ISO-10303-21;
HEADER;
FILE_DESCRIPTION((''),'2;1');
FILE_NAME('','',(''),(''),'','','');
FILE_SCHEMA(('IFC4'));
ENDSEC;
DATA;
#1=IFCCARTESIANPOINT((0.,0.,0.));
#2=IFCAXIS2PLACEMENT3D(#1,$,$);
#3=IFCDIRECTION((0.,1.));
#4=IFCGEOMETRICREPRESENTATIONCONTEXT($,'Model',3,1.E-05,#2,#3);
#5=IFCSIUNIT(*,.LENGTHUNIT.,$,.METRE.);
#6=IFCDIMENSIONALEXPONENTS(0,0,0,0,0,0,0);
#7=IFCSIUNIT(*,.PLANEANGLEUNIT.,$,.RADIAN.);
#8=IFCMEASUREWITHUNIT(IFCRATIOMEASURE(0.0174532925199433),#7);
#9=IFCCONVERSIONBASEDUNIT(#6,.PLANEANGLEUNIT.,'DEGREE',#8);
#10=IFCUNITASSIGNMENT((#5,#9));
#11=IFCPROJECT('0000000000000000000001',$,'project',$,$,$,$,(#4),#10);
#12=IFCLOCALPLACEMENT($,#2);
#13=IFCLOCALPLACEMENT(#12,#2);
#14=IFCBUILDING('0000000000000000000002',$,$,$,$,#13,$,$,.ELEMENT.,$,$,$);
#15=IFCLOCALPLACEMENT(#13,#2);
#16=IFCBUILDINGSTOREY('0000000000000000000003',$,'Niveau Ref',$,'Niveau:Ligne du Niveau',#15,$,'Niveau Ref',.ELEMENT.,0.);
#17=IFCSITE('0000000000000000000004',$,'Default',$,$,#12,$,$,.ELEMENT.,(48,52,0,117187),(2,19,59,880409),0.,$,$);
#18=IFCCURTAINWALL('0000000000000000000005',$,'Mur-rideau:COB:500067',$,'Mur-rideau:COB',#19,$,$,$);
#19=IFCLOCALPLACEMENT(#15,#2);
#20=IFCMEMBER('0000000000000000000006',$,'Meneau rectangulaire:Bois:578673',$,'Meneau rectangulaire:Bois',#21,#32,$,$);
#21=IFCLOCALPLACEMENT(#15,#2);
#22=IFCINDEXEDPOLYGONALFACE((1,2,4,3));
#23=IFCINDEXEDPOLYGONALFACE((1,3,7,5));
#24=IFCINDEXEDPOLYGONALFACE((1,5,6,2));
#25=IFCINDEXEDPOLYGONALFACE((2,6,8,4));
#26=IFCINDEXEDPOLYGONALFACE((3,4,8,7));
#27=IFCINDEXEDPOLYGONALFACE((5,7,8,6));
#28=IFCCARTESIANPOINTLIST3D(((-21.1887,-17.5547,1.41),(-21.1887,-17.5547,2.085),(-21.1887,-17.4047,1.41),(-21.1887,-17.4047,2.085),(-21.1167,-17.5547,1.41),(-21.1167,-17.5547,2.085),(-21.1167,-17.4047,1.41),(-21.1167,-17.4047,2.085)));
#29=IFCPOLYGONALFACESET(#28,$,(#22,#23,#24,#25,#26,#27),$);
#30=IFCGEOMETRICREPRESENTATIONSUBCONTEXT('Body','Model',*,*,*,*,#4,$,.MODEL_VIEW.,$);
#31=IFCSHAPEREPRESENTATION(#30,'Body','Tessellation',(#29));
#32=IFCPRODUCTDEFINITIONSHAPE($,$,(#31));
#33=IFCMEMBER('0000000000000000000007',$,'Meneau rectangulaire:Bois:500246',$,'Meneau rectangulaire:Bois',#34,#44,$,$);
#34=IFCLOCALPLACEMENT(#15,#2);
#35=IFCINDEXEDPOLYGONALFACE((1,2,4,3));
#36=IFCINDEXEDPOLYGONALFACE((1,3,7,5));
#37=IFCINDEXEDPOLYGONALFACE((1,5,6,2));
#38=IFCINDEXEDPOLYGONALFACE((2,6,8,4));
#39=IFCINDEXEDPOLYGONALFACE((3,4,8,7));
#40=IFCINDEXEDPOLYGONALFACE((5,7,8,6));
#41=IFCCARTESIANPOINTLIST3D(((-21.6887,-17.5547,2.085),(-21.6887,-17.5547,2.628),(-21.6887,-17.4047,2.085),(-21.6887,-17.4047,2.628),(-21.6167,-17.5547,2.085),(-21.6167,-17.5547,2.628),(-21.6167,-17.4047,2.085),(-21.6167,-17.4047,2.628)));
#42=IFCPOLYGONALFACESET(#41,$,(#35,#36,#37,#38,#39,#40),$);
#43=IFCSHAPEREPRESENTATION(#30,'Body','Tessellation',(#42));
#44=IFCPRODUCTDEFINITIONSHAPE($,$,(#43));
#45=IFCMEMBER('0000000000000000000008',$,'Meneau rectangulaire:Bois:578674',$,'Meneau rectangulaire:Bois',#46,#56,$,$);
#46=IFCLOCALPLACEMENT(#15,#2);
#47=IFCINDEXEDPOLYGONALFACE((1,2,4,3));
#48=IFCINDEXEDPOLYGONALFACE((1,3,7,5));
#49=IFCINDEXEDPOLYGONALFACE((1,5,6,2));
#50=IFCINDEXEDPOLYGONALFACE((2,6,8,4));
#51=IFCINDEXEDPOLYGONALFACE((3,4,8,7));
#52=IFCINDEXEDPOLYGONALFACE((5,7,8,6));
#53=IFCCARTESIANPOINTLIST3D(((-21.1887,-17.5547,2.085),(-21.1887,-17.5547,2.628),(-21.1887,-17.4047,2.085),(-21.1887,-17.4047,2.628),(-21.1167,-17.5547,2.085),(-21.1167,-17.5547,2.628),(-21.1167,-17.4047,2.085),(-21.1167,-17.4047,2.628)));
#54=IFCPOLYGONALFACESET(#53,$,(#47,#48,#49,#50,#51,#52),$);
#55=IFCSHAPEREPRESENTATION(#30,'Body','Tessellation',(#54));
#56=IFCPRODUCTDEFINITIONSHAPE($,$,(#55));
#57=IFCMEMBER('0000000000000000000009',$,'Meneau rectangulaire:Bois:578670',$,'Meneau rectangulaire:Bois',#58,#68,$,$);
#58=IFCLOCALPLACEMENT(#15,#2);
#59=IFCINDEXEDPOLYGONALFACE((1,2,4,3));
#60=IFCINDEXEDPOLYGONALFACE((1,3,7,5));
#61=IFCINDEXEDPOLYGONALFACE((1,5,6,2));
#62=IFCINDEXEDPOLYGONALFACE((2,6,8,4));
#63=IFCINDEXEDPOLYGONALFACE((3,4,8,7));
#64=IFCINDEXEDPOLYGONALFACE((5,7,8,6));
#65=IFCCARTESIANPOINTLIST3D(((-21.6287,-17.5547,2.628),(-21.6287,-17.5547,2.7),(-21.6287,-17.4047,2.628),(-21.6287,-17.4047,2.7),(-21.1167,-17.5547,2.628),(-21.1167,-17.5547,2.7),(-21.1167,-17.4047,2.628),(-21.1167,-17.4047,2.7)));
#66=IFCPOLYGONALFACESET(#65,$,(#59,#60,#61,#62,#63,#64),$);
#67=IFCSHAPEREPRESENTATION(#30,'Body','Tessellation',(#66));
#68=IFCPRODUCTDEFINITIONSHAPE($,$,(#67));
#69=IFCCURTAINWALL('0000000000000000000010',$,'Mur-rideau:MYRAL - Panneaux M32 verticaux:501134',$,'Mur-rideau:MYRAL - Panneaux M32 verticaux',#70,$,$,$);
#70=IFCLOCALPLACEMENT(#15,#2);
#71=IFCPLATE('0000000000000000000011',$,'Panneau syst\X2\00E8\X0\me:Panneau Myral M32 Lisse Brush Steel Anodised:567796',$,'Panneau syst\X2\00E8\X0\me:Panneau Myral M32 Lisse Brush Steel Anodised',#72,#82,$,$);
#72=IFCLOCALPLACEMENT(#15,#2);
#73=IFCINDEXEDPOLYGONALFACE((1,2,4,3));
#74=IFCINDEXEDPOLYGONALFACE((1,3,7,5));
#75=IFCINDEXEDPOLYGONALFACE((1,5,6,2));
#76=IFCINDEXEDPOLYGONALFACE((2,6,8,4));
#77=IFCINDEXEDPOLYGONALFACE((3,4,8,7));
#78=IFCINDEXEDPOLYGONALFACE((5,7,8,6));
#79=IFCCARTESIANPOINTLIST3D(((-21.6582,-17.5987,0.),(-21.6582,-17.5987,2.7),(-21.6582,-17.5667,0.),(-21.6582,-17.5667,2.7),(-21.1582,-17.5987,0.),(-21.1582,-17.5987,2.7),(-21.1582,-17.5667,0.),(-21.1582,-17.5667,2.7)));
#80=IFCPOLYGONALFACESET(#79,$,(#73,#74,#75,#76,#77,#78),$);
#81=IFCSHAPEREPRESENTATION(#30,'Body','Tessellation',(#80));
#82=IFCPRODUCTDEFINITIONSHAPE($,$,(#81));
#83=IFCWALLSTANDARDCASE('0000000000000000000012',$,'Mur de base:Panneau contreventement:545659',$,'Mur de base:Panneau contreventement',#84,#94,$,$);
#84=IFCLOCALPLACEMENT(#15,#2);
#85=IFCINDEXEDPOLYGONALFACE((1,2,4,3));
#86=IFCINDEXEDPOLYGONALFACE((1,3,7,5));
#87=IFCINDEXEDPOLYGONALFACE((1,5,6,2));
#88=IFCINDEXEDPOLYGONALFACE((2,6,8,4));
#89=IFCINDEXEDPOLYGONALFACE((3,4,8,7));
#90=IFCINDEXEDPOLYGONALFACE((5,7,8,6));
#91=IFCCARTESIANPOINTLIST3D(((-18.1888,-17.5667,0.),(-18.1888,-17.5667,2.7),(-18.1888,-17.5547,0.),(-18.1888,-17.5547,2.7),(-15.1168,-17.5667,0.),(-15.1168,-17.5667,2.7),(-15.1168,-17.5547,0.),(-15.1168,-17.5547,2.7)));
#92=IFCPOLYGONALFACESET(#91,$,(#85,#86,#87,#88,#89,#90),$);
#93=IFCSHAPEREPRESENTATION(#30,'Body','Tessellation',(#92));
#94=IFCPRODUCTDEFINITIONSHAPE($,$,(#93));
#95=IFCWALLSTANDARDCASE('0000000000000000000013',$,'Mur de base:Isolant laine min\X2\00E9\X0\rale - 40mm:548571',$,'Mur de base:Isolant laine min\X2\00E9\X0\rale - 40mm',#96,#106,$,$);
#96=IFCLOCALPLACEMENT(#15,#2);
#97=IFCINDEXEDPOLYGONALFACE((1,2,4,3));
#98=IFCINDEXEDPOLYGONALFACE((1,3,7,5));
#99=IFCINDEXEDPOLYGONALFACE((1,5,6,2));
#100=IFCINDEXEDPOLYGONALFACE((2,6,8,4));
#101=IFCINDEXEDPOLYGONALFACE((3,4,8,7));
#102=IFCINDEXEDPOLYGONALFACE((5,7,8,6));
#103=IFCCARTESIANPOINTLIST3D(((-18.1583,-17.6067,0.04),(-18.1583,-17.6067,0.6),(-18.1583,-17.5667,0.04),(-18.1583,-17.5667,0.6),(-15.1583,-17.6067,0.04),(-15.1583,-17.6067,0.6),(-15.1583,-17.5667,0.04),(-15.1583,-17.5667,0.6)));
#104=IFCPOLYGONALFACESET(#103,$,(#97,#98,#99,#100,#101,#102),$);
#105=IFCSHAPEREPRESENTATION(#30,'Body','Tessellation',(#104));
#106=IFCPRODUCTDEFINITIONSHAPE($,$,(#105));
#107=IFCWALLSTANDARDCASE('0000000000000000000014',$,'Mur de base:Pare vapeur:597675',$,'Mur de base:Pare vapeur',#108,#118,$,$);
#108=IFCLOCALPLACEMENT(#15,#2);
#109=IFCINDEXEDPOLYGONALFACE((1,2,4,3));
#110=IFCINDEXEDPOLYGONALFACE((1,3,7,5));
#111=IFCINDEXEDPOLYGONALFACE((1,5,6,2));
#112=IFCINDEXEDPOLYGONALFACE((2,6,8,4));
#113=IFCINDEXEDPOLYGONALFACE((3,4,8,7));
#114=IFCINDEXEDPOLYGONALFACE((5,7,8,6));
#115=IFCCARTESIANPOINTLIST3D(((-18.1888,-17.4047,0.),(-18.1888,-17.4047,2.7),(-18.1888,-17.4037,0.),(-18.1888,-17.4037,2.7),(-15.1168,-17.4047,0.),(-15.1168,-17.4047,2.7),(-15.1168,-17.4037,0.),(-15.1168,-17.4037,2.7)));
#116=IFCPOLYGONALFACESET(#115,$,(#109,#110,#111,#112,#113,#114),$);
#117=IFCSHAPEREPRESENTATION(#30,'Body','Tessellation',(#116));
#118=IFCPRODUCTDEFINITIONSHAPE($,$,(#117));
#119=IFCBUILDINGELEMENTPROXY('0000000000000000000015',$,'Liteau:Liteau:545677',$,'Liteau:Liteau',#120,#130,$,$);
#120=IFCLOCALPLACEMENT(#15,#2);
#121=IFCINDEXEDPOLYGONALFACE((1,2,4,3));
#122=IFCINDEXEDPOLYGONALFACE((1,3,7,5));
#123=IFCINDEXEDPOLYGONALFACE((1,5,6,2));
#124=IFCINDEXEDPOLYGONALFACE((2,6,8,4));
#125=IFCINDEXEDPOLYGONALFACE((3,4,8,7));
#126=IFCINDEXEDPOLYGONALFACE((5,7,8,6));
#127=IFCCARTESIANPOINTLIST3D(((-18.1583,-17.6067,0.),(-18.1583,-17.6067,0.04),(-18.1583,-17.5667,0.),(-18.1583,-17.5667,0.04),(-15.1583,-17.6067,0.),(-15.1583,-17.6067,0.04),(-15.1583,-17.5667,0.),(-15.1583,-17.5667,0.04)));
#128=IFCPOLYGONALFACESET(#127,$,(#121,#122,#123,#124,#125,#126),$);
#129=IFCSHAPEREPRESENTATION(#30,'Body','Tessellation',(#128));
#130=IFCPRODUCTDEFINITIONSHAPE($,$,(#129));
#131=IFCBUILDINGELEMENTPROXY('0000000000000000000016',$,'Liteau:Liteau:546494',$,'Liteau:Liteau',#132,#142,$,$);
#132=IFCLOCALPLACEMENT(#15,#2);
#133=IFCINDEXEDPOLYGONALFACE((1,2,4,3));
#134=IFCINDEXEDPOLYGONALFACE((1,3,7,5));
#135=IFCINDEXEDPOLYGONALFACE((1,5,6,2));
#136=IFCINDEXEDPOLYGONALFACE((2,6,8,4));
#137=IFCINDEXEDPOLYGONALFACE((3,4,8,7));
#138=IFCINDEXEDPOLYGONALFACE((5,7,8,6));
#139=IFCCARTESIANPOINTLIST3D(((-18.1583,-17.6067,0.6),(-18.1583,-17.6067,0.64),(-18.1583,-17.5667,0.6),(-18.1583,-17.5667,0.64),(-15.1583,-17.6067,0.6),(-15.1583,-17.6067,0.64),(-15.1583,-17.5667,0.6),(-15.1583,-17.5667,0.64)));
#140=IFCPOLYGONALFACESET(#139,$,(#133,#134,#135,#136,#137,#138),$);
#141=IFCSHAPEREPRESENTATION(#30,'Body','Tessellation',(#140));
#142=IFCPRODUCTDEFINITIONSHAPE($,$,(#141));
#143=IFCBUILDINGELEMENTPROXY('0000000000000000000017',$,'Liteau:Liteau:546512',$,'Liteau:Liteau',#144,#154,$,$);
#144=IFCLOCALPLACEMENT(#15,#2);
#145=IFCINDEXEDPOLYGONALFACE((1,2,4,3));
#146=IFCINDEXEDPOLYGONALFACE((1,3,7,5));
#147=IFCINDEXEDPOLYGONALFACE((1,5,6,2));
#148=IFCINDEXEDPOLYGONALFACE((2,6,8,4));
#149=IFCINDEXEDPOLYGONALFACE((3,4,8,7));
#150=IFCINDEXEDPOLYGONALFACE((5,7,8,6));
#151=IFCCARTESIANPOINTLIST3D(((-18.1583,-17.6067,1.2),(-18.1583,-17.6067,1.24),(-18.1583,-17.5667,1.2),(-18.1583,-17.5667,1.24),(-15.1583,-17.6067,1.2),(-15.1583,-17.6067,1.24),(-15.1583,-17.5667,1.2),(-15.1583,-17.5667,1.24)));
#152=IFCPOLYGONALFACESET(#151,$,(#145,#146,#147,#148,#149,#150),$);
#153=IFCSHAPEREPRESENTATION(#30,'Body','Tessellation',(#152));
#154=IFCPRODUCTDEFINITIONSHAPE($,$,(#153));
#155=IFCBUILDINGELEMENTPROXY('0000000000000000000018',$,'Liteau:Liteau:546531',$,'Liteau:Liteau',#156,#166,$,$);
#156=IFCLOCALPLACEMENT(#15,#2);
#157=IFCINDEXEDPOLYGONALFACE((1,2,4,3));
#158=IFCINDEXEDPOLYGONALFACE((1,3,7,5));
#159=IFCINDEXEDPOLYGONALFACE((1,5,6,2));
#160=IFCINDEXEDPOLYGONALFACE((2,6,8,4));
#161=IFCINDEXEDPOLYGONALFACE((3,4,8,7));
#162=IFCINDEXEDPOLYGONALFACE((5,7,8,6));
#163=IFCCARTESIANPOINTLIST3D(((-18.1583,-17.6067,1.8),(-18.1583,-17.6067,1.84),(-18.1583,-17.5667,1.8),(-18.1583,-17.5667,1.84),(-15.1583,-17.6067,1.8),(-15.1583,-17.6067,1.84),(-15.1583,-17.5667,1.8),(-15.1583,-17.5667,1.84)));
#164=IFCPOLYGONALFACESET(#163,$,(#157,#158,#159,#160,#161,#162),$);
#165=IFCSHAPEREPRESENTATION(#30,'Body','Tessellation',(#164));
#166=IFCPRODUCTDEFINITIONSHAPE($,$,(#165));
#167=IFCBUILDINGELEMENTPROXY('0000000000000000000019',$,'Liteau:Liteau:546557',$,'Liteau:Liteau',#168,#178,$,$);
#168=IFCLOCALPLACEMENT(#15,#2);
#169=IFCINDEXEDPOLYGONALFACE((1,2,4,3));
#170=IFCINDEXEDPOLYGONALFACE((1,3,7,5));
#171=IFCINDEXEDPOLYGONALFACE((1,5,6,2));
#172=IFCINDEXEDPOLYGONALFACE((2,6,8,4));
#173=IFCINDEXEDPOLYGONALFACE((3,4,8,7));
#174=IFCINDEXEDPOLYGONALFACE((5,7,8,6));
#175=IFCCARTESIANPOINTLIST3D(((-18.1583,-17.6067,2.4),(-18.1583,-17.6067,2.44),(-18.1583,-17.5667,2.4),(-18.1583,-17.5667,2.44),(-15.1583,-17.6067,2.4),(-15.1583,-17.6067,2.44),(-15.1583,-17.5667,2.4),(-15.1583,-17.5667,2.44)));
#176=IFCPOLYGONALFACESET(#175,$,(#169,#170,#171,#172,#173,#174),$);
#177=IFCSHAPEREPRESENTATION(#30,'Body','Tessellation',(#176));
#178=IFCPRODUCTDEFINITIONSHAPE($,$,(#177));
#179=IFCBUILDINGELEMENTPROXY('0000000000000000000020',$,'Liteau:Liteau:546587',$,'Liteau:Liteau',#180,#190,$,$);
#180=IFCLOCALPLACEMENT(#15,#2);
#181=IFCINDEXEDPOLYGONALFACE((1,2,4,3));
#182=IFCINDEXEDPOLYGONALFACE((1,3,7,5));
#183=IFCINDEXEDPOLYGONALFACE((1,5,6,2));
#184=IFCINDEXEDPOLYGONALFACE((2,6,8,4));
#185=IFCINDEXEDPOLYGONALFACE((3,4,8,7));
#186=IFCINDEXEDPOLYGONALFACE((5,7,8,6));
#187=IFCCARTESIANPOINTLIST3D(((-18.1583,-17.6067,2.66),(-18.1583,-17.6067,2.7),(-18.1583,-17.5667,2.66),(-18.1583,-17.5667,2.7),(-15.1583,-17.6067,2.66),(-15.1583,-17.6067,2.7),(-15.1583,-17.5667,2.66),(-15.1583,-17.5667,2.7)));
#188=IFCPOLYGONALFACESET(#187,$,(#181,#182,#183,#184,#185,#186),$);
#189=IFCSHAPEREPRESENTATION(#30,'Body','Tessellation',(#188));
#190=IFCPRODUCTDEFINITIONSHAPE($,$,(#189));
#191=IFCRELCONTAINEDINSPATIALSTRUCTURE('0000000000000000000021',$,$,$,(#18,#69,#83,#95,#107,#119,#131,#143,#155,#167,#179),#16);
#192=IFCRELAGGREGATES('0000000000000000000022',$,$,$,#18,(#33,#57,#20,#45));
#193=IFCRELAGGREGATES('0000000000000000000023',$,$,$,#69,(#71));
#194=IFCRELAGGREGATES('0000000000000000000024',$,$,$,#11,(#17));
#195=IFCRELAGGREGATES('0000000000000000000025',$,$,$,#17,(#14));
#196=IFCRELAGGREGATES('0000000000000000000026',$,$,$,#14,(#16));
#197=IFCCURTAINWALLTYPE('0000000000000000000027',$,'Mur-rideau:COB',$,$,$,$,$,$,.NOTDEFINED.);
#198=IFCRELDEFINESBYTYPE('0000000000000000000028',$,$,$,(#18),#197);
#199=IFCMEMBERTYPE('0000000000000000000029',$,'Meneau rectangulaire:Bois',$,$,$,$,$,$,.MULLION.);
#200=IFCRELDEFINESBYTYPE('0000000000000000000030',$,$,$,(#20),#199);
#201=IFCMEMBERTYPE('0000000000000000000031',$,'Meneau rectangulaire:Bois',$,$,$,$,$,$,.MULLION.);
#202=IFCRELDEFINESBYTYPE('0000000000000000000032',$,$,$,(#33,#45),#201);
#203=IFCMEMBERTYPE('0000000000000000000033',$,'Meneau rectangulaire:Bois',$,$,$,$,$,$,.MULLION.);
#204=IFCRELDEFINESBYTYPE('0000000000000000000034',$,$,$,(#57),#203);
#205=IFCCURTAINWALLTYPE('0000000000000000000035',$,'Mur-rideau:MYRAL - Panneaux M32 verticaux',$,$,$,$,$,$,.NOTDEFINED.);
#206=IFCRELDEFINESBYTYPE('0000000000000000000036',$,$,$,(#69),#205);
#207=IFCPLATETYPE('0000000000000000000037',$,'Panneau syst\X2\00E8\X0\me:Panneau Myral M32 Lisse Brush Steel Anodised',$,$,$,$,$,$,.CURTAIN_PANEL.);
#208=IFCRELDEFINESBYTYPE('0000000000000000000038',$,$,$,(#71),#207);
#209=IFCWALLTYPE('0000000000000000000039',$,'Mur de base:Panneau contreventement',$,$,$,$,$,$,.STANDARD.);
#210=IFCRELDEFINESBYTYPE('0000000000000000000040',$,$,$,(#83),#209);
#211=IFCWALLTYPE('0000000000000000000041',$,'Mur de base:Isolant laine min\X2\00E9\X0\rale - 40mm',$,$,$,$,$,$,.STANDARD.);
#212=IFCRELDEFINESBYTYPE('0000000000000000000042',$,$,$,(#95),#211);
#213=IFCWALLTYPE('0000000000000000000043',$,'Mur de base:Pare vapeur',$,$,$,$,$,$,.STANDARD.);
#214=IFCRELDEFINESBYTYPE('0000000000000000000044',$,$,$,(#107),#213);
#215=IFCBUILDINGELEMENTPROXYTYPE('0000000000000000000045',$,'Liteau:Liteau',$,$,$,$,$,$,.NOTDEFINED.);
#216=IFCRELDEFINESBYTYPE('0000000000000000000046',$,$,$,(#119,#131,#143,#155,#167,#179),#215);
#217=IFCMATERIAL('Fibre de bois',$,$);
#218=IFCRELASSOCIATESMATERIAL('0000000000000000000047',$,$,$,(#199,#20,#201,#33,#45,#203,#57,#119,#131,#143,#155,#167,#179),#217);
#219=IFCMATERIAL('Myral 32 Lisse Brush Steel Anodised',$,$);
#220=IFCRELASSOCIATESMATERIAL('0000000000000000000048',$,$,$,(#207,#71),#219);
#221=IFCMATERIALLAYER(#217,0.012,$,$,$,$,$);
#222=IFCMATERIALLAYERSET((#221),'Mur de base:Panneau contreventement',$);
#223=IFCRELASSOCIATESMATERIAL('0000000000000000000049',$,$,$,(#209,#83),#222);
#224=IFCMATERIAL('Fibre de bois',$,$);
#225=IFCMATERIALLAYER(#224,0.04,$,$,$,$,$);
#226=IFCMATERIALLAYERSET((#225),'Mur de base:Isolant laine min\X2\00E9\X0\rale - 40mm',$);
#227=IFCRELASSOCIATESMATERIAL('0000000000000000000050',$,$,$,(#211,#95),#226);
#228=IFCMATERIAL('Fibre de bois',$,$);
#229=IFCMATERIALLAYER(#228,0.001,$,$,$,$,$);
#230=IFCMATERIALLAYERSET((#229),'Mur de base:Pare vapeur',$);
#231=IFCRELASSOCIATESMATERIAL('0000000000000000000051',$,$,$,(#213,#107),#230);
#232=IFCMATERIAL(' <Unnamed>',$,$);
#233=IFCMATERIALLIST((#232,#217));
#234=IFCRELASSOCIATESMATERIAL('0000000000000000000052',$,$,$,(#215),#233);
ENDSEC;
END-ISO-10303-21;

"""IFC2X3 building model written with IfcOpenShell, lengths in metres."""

from ifc_helpers import new_model, entity, si_unit, converted_unit, direction, frame, frame_2d, origin, origin_2d_with_axis, place, context, subcontext, project, spatial, rectangle, extrude, source, transform, mapped, material, material_list, layer, layer_set, layer_usage, type_object, type_shapes, element, aggregate, save


model = new_model("IFC2X3")

# Units and contexts
model_context = context("Model", 3, precision=1e-05, world=origin(), true_north=direction((0.0, 1.0)))
body_context = subcontext(model_context, "Body", "Model", "MODEL_VIEW")
ifc_project = project(units=[si_unit("LENGTHUNIT", "METRE"), converted_unit("PLANEANGLEUNIT", "DEGREE", entity("IfcRatioMeasure", 0.0174532925199433), si_unit("PLANEANGLEUNIT", "RADIAN"), dimensions=[0, 0, 0, 0, 0, 0, 0])], contexts=[model_context])

# Site, building, storey
site_placement = place(None, origin())
site = spatial("IfcSite", under=ifc_project, at=site_placement, Name="Default", CompositionType="ELEMENT", RefLatitude=(48, 52, 0, 117187), RefLongitude=(2, 19, 59, 880409), RefElevation=0.0)
building_placement = place(site_placement, origin())
building = spatial("IfcBuilding", under=site, at=building_placement, CompositionType="ELEMENT")
storey_placement = place(building_placement, origin())
storey = spatial("IfcBuildingStorey", under=building, at=storey_placement, Name="Niveau Ref", ObjectType="Niveau:Ligne du Niveau", LongName="Niveau Ref", CompositionType="ELEMENT", Elevation=0.0)

# Curtain wall, members
curtain_wall_type_1 = type_object("IfcCurtainWallType", Name="Mur-rideau:COB", PredefinedType="NOTDEFINED")
ifc_material_1 = material(Name="Fibre de bois")
curtain_wall_1_placement = place(storey_placement, origin())
curtain_wall_1 = element("IfcCurtainWall", 1, at=curtain_wall_1_placement, inside=storey, type_object=curtain_wall_type_1, Name="Mur-rideau:COB:500067", ObjectType="Mur-rideau:COB")
member_type_1 = type_object("IfcMemberType", Name="Meneau rectangulaire:Bois", PredefinedType="MULLION", material=ifc_material_1)
shared_shape_1 = source(origin(), body_context, "Body", "SweptSolid", [
    extrude(rectangle(XDim=0.15, YDim=0.072, at=origin_2d_with_axis()), frame((-0.024, 0.0, -0.675), z_axis=(0.0, 0.0, 1.0), x_axis=(0.0, -1.0, 0.0)), (0.0, 0.0, 1.0), 0.675),
])
type_shapes(member_type_1, [shared_shape_1])
member_1_placement = place(storey_placement, frame((-21.1287, -17.4797, 1.41), z_axis=(0.0, 0.0, -1.0), x_axis=(1.0, 0.0, 0.0)))
member_1 = element("IfcMember", 2, at=member_1_placement, type_object=member_type_1, material=ifc_material_1, Name="Meneau rectangulaire:Bois:578673", ObjectType="Meneau rectangulaire:Bois", context=body_context, shape_type="MappedRepresentation", body=[
    mapped(shared_shape_1, transform((0.0, 0.0, 0.0), scale=1.0)),
])
member_type_2 = type_object("IfcMemberType", Name="Meneau rectangulaire:Bois", PredefinedType="MULLION", material=ifc_material_1)
shared_shape_2 = source(origin(), body_context, "Body", "SweptSolid", [
    extrude(rectangle(XDim=0.15, YDim=0.072, at=origin_2d_with_axis()), frame((-0.024, 0.0, -0.543), z_axis=(0.0, 0.0, 1.0), x_axis=(0.0, -1.0, 0.0)), (0.0, 0.0, 1.0), 0.543),
])
type_shapes(member_type_2, [shared_shape_2])
member_2_placement = place(storey_placement, frame((-21.6287, -17.4797, 2.085), z_axis=(0.0, 0.0, -1.0), x_axis=(1.0, 0.0, 0.0)))
member_2 = element("IfcMember", 3, at=member_2_placement, type_object=member_type_2, material=ifc_material_1, Name="Meneau rectangulaire:Bois:500246", ObjectType="Meneau rectangulaire:Bois", context=body_context, shape_type="MappedRepresentation", body=[
    mapped(shared_shape_2, transform((0.0, 0.0, 0.0), scale=1.0)),
])
member_3_placement = place(storey_placement, frame((-21.1287, -17.4797, 2.085), z_axis=(0.0, 0.0, -1.0), x_axis=(1.0, 0.0, 0.0)))
member_3 = element("IfcMember", 4, at=member_3_placement, type_object=member_type_2, material=ifc_material_1, Name="Meneau rectangulaire:Bois:578674", ObjectType="Meneau rectangulaire:Bois", context=body_context, shape_type="MappedRepresentation", body=[
    mapped(shared_shape_2, transform((0.0, 0.0, 0.0), scale=1.0)),
])
member_type_3 = type_object("IfcMemberType", Name="Meneau rectangulaire:Bois", PredefinedType="MULLION", material=ifc_material_1)
shared_shape_3 = source(origin(), body_context, "Body", "SweptSolid", [
    extrude(rectangle(XDim=0.15, YDim=0.072, at=origin_2d_with_axis()), frame((-0.036, 0.0, -0.512), z_axis=(0.0, 0.0, 1.0), x_axis=(0.0, -1.0, 0.0)), (0.0, 0.0, 1.0), 0.512),
])
type_shapes(member_type_3, [shared_shape_3])
member_4_placement = place(storey_placement, frame((-21.1167, -17.4797, 2.7), z_axis=(1.0, 0.0, 0.0), x_axis=(0.0, 0.0, 1.0)))
member_4 = element("IfcMember", 5, at=member_4_placement, type_object=member_type_3, material=ifc_material_1, Name="Meneau rectangulaire:Bois:578670", ObjectType="Meneau rectangulaire:Bois", context=body_context, shape_type="MappedRepresentation", body=[
    mapped(shared_shape_3, transform((0.0, 0.0, 0.0), scale=1.0)),
])
aggregate(curtain_wall_1, [member_2, member_4, member_1, member_3])

# Curtain wall, plate
curtain_wall_type_2 = type_object("IfcCurtainWallType", Name="Mur-rideau:MYRAL - Panneaux M32 verticaux", PredefinedType="NOTDEFINED")
curtain_wall_2_placement = place(storey_placement, origin())
curtain_wall_2 = element("IfcCurtainWall", 6, at=curtain_wall_2_placement, inside=storey, type_object=curtain_wall_type_2, Name="Mur-rideau:MYRAL - Panneaux M32 verticaux:501134", ObjectType="Mur-rideau:MYRAL - Panneaux M32 verticaux")
ifc_material_2 = material(Name="Myral 32 Lisse Brush Steel Anodised")
plate_type = type_object("IfcPlateType", Name="Panneau système:Panneau Myral M32 Lisse Brush Steel Anodised", PredefinedType="CURTAIN_PANEL", material=ifc_material_2)
shared_shape_4 = source(origin(), body_context, "Body", "SweptSolid", [
    extrude(rectangle(XDim=0.032, YDim=0.5, at=origin_2d_with_axis()), frame((0.0, -0.016, 0.0), z_axis=(0.0, 0.0, 1.0), x_axis=(0.0, 1.0, 0.0)), (0.0, 0.0, 1.0), 2.7),
])
type_shapes(plate_type, [shared_shape_4])
plate_placement = place(curtain_wall_2_placement, frame((-21.4082, -17.5667, 0.0)))
plate = element("IfcPlate", 7, at=plate_placement, type_object=plate_type, material=ifc_material_2, Name="Panneau système:Panneau Myral M32 Lisse Brush Steel Anodised:567796", ObjectType="Panneau système:Panneau Myral M32 Lisse Brush Steel Anodised", context=body_context, shape_type="MappedRepresentation", body=[
    mapped(shared_shape_4, transform((0.0, 0.0, 0.0), scale=1.0)),
])
aggregate(curtain_wall_2, [plate])

# Walls
ifc_layer_1 = layer(ifc_material_1, 0.012)
ifc_layer_set_1 = layer_set([ifc_layer_1], Name="Mur de base:Panneau contreventement")
ifc_layer_usage_1 = layer_usage(ifc_layer_set_1, "AXIS2", "NEGATIVE", 0.006)
wall_type_1 = type_object("IfcWallType", Name="Mur de base:Panneau contreventement", PredefinedType="STANDARD", material=ifc_layer_set_1)
wall_1_placement = place(storey_placement, frame((-18.1888, -17.5607, 0.0)))
element("IfcWallStandardCase", 8, at=wall_1_placement, inside=storey, type_object=wall_type_1, material=ifc_layer_usage_1, Name="Mur de base:Panneau contreventement:545659", ObjectType="Mur de base:Panneau contreventement", context=body_context, shape_type="SweptSolid", body=[
    extrude(rectangle(XDim=3.072, YDim=0.012, at=frame_2d((1.536, 0.0), x_axis=(-1.0, 0.0))), origin(), (0.0, 0.0, 1.0), 2.7),
])
ifc_material_3 = material(Name="Fibre de bois")
ifc_layer_2 = layer(ifc_material_3, 0.04)
ifc_layer_set_2 = layer_set([ifc_layer_2], Name="Mur de base:Isolant laine minérale - 40mm")
ifc_layer_usage_2 = layer_usage(ifc_layer_set_2, "AXIS2", "NEGATIVE", 0.02)
wall_type_2 = type_object("IfcWallType", Name="Mur de base:Isolant laine minérale - 40mm", PredefinedType="STANDARD", material=ifc_layer_set_2)
wall_2_placement = place(storey_placement, frame((-18.1583, -17.5867, 0.04)))
element("IfcWallStandardCase", 9, at=wall_2_placement, inside=storey, type_object=wall_type_2, material=ifc_layer_usage_2, Name="Mur de base:Isolant laine minérale - 40mm:548571", ObjectType="Mur de base:Isolant laine minérale - 40mm", context=body_context, shape_type="SweptSolid", body=[
    extrude(rectangle(XDim=3.0, YDim=0.04, at=frame_2d((1.5, 0.0), x_axis=(-1.0, 0.0))), origin(), (0.0, 0.0, 1.0), 0.56),
])
ifc_material_4 = material(Name="Fibre de bois")
ifc_layer_3 = layer(ifc_material_4, 0.001)
ifc_layer_set_3 = layer_set([ifc_layer_3], Name="Mur de base:Pare vapeur")
ifc_layer_usage_3 = layer_usage(ifc_layer_set_3, "AXIS2", "NEGATIVE", 0.0005)
wall_type_3 = type_object("IfcWallType", Name="Mur de base:Pare vapeur", PredefinedType="STANDARD", material=ifc_layer_set_3)
wall_3_placement = place(storey_placement, frame((-18.1888, -17.4042, 0.0)))
element("IfcWallStandardCase", 10, at=wall_3_placement, inside=storey, type_object=wall_type_3, material=ifc_layer_usage_3, Name="Mur de base:Pare vapeur:597675", ObjectType="Mur de base:Pare vapeur", context=body_context, shape_type="SweptSolid", body=[
    extrude(rectangle(XDim=3.072, YDim=0.001, at=frame_2d((1.536, 0.0), x_axis=(-1.0, 0.0))), origin(), (0.0, 0.0, 1.0), 2.7),
])

# Building element proxies
ifc_material_5 = material(Name=" <Unnamed>")
ifc_material_list = material_list([ifc_material_5, ifc_material_1])
building_element_proxy_type = type_object("IfcBuildingElementProxyType", Name="Liteau:Liteau", PredefinedType="NOTDEFINED", material=ifc_material_list)
shared_shape_5 = source(origin(), body_context, "Body", "SweptSolid", [
    extrude(rectangle(XDim=3.0, YDim=0.04, at=origin_2d_with_axis()), frame((1.5, -0.02, 0.0), z_axis=(0.0, 0.0, 1.0), x_axis=(-1.0, 0.0, 0.0)), (0.0, 0.0, 1.0), 0.04),
])
type_shapes(building_element_proxy_type, [shared_shape_5])
for number, where, name in (
    (11, (-18.1583, -17.5667, 0.0), "Liteau:Liteau:545677"),
    (12, (-18.1583, -17.5667, 0.6), "Liteau:Liteau:546494"),
    (13, (-18.1583, -17.5667, 1.2), "Liteau:Liteau:546512"),
    (14, (-18.1583, -17.5667, 1.8), "Liteau:Liteau:546531"),
    (15, (-18.1583, -17.5667, 2.4), "Liteau:Liteau:546557"),
    (16, (-18.1583, -17.5667, 2.66), "Liteau:Liteau:546587"),
):
    element("IfcBuildingElementProxy", number, at=place(storey_placement, frame(where)), inside=storey, type_object=building_element_proxy_type, material=ifc_material_1, Name=name, ObjectType="Liteau:Liteau", context=body_context, shape_type="MappedRepresentation", body=[
        mapped(shared_shape_5, transform((0.0, 0.0, 0.0), scale=1.0)),
    ])

save(model, "model.ifc")
